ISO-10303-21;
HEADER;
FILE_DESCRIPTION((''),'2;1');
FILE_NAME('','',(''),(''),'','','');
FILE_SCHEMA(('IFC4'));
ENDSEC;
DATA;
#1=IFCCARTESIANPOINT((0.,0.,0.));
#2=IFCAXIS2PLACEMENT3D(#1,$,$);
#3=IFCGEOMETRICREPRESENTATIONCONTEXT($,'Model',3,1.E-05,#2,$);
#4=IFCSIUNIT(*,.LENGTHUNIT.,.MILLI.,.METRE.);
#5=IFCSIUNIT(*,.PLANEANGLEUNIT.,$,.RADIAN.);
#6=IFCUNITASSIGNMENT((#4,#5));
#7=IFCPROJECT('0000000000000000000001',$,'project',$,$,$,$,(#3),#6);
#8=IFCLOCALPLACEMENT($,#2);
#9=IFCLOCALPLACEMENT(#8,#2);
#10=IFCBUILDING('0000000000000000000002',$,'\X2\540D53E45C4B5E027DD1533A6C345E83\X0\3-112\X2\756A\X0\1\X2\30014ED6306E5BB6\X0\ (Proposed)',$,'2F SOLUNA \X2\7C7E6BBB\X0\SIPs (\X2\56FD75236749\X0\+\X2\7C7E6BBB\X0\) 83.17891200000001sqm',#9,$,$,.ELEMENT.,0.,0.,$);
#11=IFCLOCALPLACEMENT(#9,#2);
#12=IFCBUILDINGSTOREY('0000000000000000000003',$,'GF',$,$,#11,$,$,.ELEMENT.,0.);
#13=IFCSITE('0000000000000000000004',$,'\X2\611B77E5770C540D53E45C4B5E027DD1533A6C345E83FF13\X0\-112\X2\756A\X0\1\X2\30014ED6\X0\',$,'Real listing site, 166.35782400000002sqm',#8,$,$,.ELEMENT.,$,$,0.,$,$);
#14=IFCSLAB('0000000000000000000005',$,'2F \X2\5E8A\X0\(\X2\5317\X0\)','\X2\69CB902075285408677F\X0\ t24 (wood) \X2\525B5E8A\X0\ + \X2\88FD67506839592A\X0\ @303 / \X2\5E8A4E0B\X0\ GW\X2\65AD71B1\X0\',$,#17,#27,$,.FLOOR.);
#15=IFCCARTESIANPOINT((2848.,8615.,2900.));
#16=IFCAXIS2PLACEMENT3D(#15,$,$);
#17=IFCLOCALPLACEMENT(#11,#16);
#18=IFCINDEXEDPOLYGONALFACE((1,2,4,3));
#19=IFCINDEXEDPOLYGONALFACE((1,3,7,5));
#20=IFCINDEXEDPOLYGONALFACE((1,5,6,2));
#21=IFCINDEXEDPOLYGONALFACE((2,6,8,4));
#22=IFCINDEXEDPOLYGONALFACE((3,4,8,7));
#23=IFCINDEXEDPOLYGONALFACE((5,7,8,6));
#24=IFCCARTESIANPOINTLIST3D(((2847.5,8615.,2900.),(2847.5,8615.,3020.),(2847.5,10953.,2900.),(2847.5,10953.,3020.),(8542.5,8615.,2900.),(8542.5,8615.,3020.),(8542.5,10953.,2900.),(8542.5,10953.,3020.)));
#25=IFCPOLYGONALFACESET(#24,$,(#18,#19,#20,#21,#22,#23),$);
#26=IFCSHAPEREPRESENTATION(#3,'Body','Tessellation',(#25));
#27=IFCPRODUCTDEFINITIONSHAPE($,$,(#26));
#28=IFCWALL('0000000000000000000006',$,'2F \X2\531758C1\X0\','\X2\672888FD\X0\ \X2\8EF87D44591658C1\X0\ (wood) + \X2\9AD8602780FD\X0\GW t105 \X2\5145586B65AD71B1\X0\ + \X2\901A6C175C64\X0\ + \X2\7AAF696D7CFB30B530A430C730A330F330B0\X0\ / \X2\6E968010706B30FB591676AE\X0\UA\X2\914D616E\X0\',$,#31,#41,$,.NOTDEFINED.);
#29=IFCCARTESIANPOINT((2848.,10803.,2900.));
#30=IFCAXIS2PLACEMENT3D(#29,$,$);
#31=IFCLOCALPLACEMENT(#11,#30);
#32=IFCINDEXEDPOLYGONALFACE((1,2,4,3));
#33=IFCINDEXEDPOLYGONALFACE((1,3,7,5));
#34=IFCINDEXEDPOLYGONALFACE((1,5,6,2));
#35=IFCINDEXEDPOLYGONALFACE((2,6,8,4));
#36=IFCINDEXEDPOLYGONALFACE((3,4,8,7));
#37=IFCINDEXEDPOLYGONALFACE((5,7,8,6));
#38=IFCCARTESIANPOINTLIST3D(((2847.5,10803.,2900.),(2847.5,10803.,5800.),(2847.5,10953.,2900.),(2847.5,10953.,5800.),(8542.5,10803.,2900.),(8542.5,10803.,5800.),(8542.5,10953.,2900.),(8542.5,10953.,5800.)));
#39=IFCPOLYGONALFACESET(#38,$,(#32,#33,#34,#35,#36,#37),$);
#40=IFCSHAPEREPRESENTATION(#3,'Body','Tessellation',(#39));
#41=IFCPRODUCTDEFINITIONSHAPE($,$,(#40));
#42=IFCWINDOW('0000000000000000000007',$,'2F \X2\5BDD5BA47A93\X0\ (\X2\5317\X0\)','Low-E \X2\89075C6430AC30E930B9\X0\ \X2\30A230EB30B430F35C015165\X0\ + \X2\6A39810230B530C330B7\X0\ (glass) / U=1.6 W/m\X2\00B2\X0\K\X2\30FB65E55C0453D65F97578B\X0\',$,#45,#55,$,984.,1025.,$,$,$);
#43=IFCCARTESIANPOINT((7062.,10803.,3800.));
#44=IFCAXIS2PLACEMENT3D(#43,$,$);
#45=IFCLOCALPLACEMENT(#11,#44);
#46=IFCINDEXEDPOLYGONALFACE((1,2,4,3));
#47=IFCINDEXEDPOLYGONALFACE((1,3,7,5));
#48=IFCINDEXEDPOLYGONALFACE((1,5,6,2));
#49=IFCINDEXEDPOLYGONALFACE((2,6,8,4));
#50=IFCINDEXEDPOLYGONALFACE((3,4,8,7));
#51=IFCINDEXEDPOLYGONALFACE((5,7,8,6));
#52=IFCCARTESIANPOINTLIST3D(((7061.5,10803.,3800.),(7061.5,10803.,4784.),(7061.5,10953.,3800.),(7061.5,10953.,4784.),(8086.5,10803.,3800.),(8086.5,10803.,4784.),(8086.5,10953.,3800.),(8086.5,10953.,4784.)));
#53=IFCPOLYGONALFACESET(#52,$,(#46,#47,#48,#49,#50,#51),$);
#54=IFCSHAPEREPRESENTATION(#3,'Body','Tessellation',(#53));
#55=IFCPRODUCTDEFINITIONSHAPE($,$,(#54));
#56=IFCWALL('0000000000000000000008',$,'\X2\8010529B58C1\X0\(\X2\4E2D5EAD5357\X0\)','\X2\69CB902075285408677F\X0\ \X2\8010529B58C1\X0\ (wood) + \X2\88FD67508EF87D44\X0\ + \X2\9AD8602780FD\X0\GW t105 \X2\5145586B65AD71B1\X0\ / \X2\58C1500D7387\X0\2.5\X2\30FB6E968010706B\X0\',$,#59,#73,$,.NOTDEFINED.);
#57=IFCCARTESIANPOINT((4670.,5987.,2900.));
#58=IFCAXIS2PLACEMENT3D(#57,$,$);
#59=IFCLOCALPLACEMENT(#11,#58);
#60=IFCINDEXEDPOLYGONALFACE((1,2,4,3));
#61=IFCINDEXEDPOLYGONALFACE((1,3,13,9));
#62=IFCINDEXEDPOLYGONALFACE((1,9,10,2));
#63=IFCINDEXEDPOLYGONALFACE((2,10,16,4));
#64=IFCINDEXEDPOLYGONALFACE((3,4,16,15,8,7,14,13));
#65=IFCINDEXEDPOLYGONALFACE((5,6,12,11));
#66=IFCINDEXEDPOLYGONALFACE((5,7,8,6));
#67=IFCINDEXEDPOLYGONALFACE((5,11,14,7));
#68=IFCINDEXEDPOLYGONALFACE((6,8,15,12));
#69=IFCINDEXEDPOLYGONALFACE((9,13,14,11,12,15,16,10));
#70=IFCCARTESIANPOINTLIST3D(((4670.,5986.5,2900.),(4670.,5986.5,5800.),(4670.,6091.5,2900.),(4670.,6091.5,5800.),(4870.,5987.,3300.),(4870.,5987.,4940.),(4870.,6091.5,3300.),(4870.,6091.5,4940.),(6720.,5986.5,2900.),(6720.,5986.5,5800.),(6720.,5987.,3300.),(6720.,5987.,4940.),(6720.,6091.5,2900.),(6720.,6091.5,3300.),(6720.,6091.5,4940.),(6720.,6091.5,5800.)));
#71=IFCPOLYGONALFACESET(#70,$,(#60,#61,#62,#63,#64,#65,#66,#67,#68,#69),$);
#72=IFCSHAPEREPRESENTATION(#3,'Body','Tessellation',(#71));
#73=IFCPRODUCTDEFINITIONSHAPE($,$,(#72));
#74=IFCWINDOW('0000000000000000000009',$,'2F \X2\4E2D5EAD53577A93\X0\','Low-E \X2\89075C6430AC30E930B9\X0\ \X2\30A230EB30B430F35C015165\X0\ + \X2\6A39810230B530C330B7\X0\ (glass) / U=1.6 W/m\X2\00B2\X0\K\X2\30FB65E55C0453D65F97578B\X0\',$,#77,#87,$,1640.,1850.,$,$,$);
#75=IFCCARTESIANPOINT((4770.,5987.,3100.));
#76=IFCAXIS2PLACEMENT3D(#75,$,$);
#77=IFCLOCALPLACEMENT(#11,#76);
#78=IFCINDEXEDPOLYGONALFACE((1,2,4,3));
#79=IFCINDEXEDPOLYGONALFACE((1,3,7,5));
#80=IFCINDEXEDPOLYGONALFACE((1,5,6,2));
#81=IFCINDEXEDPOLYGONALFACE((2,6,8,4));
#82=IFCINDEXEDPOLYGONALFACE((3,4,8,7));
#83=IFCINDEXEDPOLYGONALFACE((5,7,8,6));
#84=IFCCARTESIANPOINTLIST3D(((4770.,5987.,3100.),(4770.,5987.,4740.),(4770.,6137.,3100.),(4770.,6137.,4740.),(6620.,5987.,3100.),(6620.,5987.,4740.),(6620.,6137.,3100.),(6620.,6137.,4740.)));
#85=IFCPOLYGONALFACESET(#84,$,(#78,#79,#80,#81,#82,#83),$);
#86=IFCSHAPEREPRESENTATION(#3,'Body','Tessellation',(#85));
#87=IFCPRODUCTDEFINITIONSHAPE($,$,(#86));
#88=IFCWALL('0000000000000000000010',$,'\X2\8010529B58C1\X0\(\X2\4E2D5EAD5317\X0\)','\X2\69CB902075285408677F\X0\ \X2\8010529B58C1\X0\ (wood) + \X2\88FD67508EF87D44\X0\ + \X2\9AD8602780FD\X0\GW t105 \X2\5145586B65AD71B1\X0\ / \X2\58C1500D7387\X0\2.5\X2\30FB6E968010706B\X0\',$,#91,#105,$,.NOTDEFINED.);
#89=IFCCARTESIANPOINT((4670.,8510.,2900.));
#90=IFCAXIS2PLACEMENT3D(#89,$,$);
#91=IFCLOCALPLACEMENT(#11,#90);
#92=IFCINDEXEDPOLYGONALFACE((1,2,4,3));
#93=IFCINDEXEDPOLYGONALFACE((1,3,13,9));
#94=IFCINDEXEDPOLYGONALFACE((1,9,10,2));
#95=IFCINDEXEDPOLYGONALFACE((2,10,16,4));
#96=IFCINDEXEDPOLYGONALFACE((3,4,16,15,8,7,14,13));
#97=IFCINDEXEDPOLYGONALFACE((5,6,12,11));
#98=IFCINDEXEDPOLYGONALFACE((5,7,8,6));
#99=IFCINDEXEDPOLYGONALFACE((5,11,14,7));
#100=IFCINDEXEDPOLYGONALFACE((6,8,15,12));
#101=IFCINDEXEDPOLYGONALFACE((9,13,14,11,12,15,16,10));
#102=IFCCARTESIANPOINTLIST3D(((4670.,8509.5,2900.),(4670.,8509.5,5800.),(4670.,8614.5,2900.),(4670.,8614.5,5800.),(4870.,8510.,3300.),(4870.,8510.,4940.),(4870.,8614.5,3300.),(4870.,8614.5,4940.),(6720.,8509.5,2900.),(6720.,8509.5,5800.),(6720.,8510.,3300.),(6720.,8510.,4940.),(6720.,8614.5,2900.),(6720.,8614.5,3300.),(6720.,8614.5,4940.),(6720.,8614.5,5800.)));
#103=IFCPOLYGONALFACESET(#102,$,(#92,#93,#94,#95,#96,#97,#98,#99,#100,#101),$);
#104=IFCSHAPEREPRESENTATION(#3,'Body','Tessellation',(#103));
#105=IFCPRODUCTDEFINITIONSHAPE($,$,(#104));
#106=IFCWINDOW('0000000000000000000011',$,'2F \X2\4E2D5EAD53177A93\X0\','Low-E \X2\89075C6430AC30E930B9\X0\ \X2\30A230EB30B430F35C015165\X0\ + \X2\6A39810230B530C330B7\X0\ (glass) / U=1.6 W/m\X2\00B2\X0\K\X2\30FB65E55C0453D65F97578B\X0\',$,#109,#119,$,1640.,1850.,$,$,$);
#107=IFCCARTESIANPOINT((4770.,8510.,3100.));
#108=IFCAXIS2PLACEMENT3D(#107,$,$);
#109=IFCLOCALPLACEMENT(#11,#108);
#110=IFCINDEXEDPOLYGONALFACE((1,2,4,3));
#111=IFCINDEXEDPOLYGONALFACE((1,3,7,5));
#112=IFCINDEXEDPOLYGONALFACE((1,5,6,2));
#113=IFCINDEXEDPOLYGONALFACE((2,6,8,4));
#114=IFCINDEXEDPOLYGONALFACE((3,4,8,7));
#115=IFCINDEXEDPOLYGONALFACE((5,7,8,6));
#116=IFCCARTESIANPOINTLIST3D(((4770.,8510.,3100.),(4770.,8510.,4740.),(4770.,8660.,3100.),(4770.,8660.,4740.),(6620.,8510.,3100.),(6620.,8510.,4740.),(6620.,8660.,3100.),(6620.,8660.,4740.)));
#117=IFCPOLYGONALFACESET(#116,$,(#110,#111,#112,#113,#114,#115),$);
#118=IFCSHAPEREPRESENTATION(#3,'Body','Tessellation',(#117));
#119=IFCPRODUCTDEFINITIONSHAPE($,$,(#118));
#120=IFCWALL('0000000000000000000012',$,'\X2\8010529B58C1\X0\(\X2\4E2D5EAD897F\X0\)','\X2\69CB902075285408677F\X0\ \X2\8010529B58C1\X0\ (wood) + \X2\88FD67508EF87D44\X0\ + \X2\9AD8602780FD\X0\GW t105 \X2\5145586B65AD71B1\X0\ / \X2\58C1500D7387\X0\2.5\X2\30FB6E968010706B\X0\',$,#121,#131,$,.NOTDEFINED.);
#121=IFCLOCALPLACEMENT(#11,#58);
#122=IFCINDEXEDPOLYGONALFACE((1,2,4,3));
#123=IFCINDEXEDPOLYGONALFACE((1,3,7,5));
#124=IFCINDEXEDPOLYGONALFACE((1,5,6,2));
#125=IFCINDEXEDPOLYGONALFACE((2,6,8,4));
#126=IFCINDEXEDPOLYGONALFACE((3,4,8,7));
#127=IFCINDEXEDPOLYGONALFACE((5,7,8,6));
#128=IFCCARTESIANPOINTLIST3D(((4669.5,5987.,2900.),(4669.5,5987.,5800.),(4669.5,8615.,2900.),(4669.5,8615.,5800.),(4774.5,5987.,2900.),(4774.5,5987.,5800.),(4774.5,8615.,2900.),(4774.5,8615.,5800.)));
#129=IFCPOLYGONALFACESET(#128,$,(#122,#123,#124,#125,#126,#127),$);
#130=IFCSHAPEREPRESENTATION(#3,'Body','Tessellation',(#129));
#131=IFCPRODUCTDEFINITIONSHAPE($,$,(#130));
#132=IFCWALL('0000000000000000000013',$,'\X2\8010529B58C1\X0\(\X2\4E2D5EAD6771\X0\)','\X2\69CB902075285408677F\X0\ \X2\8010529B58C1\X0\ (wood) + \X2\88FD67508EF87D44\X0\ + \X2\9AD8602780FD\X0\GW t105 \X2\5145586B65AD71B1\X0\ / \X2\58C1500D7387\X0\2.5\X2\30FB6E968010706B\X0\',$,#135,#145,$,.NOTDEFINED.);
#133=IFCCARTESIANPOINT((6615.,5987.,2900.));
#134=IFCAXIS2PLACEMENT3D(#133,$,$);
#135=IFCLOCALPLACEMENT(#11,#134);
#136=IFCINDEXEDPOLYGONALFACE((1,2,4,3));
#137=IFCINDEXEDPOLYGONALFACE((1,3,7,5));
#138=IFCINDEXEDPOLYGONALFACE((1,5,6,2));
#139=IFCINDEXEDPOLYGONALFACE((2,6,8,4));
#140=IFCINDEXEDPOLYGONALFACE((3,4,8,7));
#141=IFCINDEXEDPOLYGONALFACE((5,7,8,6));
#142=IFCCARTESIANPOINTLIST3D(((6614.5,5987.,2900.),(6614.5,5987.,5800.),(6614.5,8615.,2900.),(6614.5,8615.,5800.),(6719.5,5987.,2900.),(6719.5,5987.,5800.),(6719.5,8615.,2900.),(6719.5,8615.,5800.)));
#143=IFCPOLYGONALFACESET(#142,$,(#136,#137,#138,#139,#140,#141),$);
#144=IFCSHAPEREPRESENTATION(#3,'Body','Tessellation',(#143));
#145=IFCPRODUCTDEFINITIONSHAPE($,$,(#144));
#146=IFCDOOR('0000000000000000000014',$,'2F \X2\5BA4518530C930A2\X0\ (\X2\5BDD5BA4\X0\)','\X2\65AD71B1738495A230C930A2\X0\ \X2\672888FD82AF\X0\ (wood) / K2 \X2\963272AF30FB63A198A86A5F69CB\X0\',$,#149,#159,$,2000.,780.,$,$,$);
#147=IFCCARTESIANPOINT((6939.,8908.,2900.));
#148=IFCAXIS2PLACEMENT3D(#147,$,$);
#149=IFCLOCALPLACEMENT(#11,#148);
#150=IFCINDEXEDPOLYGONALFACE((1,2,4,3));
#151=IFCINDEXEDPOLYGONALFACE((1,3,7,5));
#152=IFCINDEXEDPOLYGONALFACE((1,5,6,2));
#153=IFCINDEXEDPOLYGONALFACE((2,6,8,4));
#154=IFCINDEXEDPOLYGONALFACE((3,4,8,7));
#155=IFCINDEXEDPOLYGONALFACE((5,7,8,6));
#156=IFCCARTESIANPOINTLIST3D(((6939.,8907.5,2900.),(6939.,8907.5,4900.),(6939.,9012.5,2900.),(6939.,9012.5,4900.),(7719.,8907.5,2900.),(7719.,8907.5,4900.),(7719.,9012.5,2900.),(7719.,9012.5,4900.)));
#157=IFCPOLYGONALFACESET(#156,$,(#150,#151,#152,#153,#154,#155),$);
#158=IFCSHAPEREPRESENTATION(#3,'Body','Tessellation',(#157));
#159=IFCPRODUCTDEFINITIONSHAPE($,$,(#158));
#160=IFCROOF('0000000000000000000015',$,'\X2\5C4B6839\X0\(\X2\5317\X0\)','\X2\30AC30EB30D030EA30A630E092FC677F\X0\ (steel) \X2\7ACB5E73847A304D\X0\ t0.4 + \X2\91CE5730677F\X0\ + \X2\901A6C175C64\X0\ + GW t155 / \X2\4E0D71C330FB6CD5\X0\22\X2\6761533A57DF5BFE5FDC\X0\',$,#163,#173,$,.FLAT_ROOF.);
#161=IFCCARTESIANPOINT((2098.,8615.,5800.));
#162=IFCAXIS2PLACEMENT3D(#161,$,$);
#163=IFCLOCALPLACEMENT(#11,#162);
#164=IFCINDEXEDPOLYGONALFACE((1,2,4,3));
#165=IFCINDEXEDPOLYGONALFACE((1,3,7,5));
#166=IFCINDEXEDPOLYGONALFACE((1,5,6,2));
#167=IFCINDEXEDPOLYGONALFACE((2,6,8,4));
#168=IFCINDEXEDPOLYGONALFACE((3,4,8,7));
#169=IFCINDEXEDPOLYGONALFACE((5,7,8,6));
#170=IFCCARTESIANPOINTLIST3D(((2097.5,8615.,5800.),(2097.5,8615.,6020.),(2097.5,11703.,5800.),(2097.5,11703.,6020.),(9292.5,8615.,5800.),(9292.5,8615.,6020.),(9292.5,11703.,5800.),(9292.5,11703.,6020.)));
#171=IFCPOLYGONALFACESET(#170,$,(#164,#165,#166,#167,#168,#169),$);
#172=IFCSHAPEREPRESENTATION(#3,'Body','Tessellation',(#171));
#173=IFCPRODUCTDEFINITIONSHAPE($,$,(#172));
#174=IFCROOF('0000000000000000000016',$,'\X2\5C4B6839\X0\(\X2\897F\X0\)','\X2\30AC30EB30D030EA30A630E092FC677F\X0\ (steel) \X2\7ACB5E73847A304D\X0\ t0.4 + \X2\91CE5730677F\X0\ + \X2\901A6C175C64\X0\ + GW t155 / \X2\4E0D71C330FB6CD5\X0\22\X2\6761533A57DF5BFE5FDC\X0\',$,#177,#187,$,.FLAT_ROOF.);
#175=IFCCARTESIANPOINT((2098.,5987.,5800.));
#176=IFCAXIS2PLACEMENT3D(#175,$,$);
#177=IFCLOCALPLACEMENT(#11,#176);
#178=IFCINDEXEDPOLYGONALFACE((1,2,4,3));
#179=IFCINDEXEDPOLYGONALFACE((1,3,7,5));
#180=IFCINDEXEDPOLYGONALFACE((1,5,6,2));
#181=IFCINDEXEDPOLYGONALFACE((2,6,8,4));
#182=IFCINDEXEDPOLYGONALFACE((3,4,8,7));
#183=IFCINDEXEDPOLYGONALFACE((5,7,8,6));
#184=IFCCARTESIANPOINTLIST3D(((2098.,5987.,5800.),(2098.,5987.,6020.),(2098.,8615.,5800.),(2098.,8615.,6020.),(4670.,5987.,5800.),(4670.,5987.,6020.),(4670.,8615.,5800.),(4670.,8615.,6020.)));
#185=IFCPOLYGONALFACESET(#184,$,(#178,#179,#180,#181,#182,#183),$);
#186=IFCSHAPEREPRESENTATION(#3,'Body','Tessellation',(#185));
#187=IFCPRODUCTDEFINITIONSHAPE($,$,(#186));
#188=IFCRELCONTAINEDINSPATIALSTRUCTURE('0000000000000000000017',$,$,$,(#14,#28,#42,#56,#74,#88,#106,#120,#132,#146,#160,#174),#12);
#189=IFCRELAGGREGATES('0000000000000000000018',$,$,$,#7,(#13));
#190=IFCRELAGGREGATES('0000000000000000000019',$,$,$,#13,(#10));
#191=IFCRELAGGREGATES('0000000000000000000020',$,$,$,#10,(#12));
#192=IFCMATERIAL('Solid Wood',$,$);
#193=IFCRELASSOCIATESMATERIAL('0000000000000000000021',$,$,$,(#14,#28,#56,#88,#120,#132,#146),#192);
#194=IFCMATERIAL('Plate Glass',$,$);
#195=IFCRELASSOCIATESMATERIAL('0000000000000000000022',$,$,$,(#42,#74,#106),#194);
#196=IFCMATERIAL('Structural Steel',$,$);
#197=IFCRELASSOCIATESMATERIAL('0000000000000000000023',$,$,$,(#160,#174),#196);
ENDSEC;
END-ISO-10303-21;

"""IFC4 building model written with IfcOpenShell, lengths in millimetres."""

from ifc_helpers import new_model, si_unit, frame, frame_2d, origin, place, context, project, spatial, rectangle, extrude, material, element, fill, save


model = new_model("IFC4")

# Units and contexts
model_context = context("Model", 3, precision=1e-05, world=origin())
ifc_project = project(units=[si_unit("LENGTHUNIT", "METRE", prefix="MILLI"), si_unit("PLANEANGLEUNIT", "RADIAN")], contexts=[model_context])

# Site, building, storey
site_placement = place(None, origin())
site = spatial("IfcSite", under=ifc_project, at=site_placement, Name="愛知県名古屋市緑区水広３-112番1、他", ObjectType="Real listing site, 166.35782400000002sqm", CompositionType="ELEMENT", RefElevation=0.0)
building_placement = place(site_placement, origin())
building = spatial("IfcBuilding", under=site, at=building_placement, Name="名古屋市緑区水広3-112番1、他の家 (Proposed)", ObjectType="2F SOLUNA 籾殻SIPs (国産杉+籾殻) 83.17891200000001sqm", CompositionType="ELEMENT", ElevationOfRefHeight=0.0, ElevationOfTerrain=0.0)
storey_placement = place(building_placement, origin())
storey = spatial("IfcBuildingStorey", under=building, at=storey_placement, Name="GF", CompositionType="ELEMENT", Elevation=0.0)

# Slab
ifc_material_1 = material(Name="Solid Wood")
slab_placement = place(storey_placement, frame((2848.0, 8615.0, 2900.0)))
element("IfcSlab", 1, at=slab_placement, inside=storey, material=ifc_material_1, Name="2F 床(北)", Description="構造用合板 t24 (wood) 剛床 + 製材根太 @303 / 床下 GW断熱", PredefinedType="FLOOR", context=model_context, shape_type="SweptSolid", body=[
    extrude(rectangle(XDim=5695.0, YDim=2338.0, at=frame_2d((2847.0, 1169.0))), frame((2848.0, 8615.0, 2900.0)), (0.0, 0.0, 1.0), 120.0),
])

# Walls, openings, windows
wall_1_placement = place(storey_placement, frame((2848.0, 10803.0, 2900.0)))
wall_1 = element("IfcWall", 2, at=wall_1_placement, inside=storey, material=ifc_material_1, Name="2F 北壁", Description="木製 軸組外壁 (wood) + 高性能GW t105 充填断熱 + 通気層 + 窯業系サイディング / 準耐火・外皮UA配慮", PredefinedType="NOTDEFINED", context=model_context, shape_type="SweptSolid", body=[
    extrude(rectangle(XDim=5695.0, YDim=150.0, at=frame_2d((2847.0, 75.0))), frame((2848.0, 10803.0, 2900.0)), (0.0, 0.0, 1.0), 2900.0),
])
opening_1_placement = place(storey_placement, frame((7062.0, 10803.0, 3800.0)))
opening_1 = element("IfcOpeningElement", 3, at=opening_1_placement, cuts=wall_1, PredefinedType="NOTDEFINED", context=model_context, shape_type="SweptSolid", body=[
    extrude(rectangle(XDim=1025.0, YDim=150.0, at=frame_2d((512.0, 75.0))), frame((7062.0, 10803.0, 3800.0)), (0.0, 0.0, 1.0), 984.0),
])
ifc_material_2 = material(Name="Plate Glass")
window_1_placement = place(storey_placement, frame((7062.0, 10803.0, 3800.0)))
window_1 = element("IfcWindow", 4, at=window_1_placement, inside=storey, material=ifc_material_2, Name="2F 寝室窓 (北)", Description="Low-E 複層ガラス アルゴン封入 + 樹脂サッシ (glass) / U=1.6 W/m²K・日射取得型", OverallHeight=984.0, OverallWidth=1025.0, context=model_context, shape_type="SweptSolid", body=[
    extrude(rectangle(XDim=1025.0, YDim=150.0, at=frame_2d((512.0, 75.0))), frame((7062.0, 10803.0, 3800.0)), (0.0, 0.0, 1.0), 984.0),
])
fill(opening_1, window_1)
wall_2_placement = place(storey_placement, frame((4670.0, 5987.0, 2900.0)))
wall_2 = element("IfcWall", 5, at=wall_2_placement, inside=storey, material=ifc_material_1, Name="耐力壁(中庭南)", Description="構造用合板 耐力壁 (wood) + 製材軸組 + 高性能GW t105 充填断熱 / 壁倍率2.5・準耐火", PredefinedType="NOTDEFINED", context=model_context, shape_type="SweptSolid", body=[
    extrude(rectangle(XDim=2050.0, YDim=105.0, at=frame_2d((1025.0, 52.0))), frame((4670.0, 5987.0, 2900.0)), (0.0, 0.0, 1.0), 2900.0),
])
opening_2_placement = place(storey_placement, frame((4770.0, 5987.0, 3100.0)))
opening_2 = element("IfcOpeningElement", 6, at=opening_2_placement, cuts=wall_2, PredefinedType="NOTDEFINED", context=model_context, shape_type="SweptSolid", body=[
    extrude(rectangle(XDim=1850.0, YDim=150.0, at=frame_2d((925.0, 75.0))), frame((4770.0, 5987.0, 3100.0)), (0.0, 0.0, 1.0), 1640.0),
])
window_2_placement = place(storey_placement, frame((4770.0, 5987.0, 3100.0)))
window_2 = element("IfcWindow", 7, at=window_2_placement, inside=storey, material=ifc_material_2, Name="2F 中庭南窓", Description="Low-E 複層ガラス アルゴン封入 + 樹脂サッシ (glass) / U=1.6 W/m²K・日射取得型", OverallHeight=1640.0, OverallWidth=1850.0, context=model_context, shape_type="SweptSolid", body=[
    extrude(rectangle(XDim=1850.0, YDim=150.0, at=frame_2d((925.0, 75.0))), frame((4770.0, 5987.0, 3100.0)), (0.0, 0.0, 1.0), 1640.0),
])
fill(opening_2, window_2)
wall_3_placement = place(storey_placement, frame((4670.0, 8510.0, 2900.0)))
wall_3 = element("IfcWall", 8, at=wall_3_placement, inside=storey, material=ifc_material_1, Name="耐力壁(中庭北)", Description="構造用合板 耐力壁 (wood) + 製材軸組 + 高性能GW t105 充填断熱 / 壁倍率2.5・準耐火", PredefinedType="NOTDEFINED", context=model_context, shape_type="SweptSolid", body=[
    extrude(rectangle(XDim=2050.0, YDim=105.0, at=frame_2d((1025.0, 52.0))), frame((4670.0, 8510.0, 2900.0)), (0.0, 0.0, 1.0), 2900.0),
])
opening_3_placement = place(storey_placement, frame((4770.0, 8510.0, 3100.0)))
opening_3 = element("IfcOpeningElement", 9, at=opening_3_placement, cuts=wall_3, PredefinedType="NOTDEFINED", context=model_context, shape_type="SweptSolid", body=[
    extrude(rectangle(XDim=1850.0, YDim=150.0, at=frame_2d((925.0, 75.0))), frame((4770.0, 8510.0, 3100.0)), (0.0, 0.0, 1.0), 1640.0),
])
window_3_placement = place(storey_placement, frame((4770.0, 8510.0, 3100.0)))
window_3 = element("IfcWindow", 10, at=window_3_placement, inside=storey, material=ifc_material_2, Name="2F 中庭北窓", Description="Low-E 複層ガラス アルゴン封入 + 樹脂サッシ (glass) / U=1.6 W/m²K・日射取得型", OverallHeight=1640.0, OverallWidth=1850.0, context=model_context, shape_type="SweptSolid", body=[
    extrude(rectangle(XDim=1850.0, YDim=150.0, at=frame_2d((925.0, 75.0))), frame((4770.0, 8510.0, 3100.0)), (0.0, 0.0, 1.0), 1640.0),
])
fill(opening_3, window_3)

# Walls
wall_4_placement = place(storey_placement, frame((4670.0, 5987.0, 2900.0)))
element("IfcWall", 11, at=wall_4_placement, inside=storey, material=ifc_material_1, Name="耐力壁(中庭西)", Description="構造用合板 耐力壁 (wood) + 製材軸組 + 高性能GW t105 充填断熱 / 壁倍率2.5・準耐火", PredefinedType="NOTDEFINED", context=model_context, shape_type="SweptSolid", body=[
    extrude(rectangle(XDim=105.0, YDim=2628.0, at=frame_2d((52.0, 1314.0))), frame((4670.0, 5987.0, 2900.0)), (0.0, 0.0, 1.0), 2900.0),
])
wall_5_placement = place(storey_placement, frame((6615.0, 5987.0, 2900.0)))
element("IfcWall", 12, at=wall_5_placement, inside=storey, material=ifc_material_1, Name="耐力壁(中庭東)", Description="構造用合板 耐力壁 (wood) + 製材軸組 + 高性能GW t105 充填断熱 / 壁倍率2.5・準耐火", PredefinedType="NOTDEFINED", context=model_context, shape_type="SweptSolid", body=[
    extrude(rectangle(XDim=105.0, YDim=2628.0, at=frame_2d((52.0, 1314.0))), frame((6615.0, 5987.0, 2900.0)), (0.0, 0.0, 1.0), 2900.0),
])

# Door
door_placement = place(storey_placement, frame((6939.0, 8908.0, 2900.0)))
element("IfcDoor", 13, at=door_placement, inside=storey, material=ifc_material_1, Name="2F 室内ドア (寝室)", Description="断熱玄関ドア 木製芯 (wood) / K2 防犯・採風機構", OverallHeight=2000.0, OverallWidth=780.0, context=model_context, shape_type="SweptSolid", body=[
    extrude(rectangle(XDim=780.0, YDim=105.0, at=frame_2d((390.0, 52.0))), frame((6939.0, 8908.0, 2900.0)), (0.0, 0.0, 1.0), 2000.0),
])

# Roofs
ifc_material_3 = material(Name="Structural Steel")
for number, where, name in (
    (14, (2098.0, 8615.0, 5800.0), "屋根(北)"),
):
    element("IfcRoof", number, at=place(storey_placement, frame(where)), inside=storey, material=ifc_material_3, Name=name, Description="ガルバリウム鋼板 (steel) 立平葺き t0.4 + 野地板 + 通気層 + GW t155 / 不燃・法22条区域対応", PredefinedType="FLAT_ROOF", context=model_context, shape_type="SweptSolid", body=[
        extrude(rectangle(XDim=7195.0, YDim=3088.0, at=frame_2d((3597.0, 1544.0))), frame((2098.0, 8615.0, 5800.0)), (0.0, 0.0, 1.0), 220.0),
    ])
roof_1_placement = place(storey_placement, frame((2098.0, 5987.0, 5800.0)))
element("IfcRoof", 15, at=roof_1_placement, inside=storey, material=ifc_material_3, Name="屋根(西)", Description="ガルバリウム鋼板 (steel) 立平葺き t0.4 + 野地板 + 通気層 + GW t155 / 不燃・法22条区域対応", PredefinedType="FLAT_ROOF", context=model_context, shape_type="SweptSolid", body=[
    extrude(rectangle(XDim=2572.0, YDim=2628.0, at=frame_2d((1286.0, 1314.0))), frame((2098.0, 5987.0, 5800.0)), (0.0, 0.0, 1.0), 220.0),
])

save(model, "model.ifc")
